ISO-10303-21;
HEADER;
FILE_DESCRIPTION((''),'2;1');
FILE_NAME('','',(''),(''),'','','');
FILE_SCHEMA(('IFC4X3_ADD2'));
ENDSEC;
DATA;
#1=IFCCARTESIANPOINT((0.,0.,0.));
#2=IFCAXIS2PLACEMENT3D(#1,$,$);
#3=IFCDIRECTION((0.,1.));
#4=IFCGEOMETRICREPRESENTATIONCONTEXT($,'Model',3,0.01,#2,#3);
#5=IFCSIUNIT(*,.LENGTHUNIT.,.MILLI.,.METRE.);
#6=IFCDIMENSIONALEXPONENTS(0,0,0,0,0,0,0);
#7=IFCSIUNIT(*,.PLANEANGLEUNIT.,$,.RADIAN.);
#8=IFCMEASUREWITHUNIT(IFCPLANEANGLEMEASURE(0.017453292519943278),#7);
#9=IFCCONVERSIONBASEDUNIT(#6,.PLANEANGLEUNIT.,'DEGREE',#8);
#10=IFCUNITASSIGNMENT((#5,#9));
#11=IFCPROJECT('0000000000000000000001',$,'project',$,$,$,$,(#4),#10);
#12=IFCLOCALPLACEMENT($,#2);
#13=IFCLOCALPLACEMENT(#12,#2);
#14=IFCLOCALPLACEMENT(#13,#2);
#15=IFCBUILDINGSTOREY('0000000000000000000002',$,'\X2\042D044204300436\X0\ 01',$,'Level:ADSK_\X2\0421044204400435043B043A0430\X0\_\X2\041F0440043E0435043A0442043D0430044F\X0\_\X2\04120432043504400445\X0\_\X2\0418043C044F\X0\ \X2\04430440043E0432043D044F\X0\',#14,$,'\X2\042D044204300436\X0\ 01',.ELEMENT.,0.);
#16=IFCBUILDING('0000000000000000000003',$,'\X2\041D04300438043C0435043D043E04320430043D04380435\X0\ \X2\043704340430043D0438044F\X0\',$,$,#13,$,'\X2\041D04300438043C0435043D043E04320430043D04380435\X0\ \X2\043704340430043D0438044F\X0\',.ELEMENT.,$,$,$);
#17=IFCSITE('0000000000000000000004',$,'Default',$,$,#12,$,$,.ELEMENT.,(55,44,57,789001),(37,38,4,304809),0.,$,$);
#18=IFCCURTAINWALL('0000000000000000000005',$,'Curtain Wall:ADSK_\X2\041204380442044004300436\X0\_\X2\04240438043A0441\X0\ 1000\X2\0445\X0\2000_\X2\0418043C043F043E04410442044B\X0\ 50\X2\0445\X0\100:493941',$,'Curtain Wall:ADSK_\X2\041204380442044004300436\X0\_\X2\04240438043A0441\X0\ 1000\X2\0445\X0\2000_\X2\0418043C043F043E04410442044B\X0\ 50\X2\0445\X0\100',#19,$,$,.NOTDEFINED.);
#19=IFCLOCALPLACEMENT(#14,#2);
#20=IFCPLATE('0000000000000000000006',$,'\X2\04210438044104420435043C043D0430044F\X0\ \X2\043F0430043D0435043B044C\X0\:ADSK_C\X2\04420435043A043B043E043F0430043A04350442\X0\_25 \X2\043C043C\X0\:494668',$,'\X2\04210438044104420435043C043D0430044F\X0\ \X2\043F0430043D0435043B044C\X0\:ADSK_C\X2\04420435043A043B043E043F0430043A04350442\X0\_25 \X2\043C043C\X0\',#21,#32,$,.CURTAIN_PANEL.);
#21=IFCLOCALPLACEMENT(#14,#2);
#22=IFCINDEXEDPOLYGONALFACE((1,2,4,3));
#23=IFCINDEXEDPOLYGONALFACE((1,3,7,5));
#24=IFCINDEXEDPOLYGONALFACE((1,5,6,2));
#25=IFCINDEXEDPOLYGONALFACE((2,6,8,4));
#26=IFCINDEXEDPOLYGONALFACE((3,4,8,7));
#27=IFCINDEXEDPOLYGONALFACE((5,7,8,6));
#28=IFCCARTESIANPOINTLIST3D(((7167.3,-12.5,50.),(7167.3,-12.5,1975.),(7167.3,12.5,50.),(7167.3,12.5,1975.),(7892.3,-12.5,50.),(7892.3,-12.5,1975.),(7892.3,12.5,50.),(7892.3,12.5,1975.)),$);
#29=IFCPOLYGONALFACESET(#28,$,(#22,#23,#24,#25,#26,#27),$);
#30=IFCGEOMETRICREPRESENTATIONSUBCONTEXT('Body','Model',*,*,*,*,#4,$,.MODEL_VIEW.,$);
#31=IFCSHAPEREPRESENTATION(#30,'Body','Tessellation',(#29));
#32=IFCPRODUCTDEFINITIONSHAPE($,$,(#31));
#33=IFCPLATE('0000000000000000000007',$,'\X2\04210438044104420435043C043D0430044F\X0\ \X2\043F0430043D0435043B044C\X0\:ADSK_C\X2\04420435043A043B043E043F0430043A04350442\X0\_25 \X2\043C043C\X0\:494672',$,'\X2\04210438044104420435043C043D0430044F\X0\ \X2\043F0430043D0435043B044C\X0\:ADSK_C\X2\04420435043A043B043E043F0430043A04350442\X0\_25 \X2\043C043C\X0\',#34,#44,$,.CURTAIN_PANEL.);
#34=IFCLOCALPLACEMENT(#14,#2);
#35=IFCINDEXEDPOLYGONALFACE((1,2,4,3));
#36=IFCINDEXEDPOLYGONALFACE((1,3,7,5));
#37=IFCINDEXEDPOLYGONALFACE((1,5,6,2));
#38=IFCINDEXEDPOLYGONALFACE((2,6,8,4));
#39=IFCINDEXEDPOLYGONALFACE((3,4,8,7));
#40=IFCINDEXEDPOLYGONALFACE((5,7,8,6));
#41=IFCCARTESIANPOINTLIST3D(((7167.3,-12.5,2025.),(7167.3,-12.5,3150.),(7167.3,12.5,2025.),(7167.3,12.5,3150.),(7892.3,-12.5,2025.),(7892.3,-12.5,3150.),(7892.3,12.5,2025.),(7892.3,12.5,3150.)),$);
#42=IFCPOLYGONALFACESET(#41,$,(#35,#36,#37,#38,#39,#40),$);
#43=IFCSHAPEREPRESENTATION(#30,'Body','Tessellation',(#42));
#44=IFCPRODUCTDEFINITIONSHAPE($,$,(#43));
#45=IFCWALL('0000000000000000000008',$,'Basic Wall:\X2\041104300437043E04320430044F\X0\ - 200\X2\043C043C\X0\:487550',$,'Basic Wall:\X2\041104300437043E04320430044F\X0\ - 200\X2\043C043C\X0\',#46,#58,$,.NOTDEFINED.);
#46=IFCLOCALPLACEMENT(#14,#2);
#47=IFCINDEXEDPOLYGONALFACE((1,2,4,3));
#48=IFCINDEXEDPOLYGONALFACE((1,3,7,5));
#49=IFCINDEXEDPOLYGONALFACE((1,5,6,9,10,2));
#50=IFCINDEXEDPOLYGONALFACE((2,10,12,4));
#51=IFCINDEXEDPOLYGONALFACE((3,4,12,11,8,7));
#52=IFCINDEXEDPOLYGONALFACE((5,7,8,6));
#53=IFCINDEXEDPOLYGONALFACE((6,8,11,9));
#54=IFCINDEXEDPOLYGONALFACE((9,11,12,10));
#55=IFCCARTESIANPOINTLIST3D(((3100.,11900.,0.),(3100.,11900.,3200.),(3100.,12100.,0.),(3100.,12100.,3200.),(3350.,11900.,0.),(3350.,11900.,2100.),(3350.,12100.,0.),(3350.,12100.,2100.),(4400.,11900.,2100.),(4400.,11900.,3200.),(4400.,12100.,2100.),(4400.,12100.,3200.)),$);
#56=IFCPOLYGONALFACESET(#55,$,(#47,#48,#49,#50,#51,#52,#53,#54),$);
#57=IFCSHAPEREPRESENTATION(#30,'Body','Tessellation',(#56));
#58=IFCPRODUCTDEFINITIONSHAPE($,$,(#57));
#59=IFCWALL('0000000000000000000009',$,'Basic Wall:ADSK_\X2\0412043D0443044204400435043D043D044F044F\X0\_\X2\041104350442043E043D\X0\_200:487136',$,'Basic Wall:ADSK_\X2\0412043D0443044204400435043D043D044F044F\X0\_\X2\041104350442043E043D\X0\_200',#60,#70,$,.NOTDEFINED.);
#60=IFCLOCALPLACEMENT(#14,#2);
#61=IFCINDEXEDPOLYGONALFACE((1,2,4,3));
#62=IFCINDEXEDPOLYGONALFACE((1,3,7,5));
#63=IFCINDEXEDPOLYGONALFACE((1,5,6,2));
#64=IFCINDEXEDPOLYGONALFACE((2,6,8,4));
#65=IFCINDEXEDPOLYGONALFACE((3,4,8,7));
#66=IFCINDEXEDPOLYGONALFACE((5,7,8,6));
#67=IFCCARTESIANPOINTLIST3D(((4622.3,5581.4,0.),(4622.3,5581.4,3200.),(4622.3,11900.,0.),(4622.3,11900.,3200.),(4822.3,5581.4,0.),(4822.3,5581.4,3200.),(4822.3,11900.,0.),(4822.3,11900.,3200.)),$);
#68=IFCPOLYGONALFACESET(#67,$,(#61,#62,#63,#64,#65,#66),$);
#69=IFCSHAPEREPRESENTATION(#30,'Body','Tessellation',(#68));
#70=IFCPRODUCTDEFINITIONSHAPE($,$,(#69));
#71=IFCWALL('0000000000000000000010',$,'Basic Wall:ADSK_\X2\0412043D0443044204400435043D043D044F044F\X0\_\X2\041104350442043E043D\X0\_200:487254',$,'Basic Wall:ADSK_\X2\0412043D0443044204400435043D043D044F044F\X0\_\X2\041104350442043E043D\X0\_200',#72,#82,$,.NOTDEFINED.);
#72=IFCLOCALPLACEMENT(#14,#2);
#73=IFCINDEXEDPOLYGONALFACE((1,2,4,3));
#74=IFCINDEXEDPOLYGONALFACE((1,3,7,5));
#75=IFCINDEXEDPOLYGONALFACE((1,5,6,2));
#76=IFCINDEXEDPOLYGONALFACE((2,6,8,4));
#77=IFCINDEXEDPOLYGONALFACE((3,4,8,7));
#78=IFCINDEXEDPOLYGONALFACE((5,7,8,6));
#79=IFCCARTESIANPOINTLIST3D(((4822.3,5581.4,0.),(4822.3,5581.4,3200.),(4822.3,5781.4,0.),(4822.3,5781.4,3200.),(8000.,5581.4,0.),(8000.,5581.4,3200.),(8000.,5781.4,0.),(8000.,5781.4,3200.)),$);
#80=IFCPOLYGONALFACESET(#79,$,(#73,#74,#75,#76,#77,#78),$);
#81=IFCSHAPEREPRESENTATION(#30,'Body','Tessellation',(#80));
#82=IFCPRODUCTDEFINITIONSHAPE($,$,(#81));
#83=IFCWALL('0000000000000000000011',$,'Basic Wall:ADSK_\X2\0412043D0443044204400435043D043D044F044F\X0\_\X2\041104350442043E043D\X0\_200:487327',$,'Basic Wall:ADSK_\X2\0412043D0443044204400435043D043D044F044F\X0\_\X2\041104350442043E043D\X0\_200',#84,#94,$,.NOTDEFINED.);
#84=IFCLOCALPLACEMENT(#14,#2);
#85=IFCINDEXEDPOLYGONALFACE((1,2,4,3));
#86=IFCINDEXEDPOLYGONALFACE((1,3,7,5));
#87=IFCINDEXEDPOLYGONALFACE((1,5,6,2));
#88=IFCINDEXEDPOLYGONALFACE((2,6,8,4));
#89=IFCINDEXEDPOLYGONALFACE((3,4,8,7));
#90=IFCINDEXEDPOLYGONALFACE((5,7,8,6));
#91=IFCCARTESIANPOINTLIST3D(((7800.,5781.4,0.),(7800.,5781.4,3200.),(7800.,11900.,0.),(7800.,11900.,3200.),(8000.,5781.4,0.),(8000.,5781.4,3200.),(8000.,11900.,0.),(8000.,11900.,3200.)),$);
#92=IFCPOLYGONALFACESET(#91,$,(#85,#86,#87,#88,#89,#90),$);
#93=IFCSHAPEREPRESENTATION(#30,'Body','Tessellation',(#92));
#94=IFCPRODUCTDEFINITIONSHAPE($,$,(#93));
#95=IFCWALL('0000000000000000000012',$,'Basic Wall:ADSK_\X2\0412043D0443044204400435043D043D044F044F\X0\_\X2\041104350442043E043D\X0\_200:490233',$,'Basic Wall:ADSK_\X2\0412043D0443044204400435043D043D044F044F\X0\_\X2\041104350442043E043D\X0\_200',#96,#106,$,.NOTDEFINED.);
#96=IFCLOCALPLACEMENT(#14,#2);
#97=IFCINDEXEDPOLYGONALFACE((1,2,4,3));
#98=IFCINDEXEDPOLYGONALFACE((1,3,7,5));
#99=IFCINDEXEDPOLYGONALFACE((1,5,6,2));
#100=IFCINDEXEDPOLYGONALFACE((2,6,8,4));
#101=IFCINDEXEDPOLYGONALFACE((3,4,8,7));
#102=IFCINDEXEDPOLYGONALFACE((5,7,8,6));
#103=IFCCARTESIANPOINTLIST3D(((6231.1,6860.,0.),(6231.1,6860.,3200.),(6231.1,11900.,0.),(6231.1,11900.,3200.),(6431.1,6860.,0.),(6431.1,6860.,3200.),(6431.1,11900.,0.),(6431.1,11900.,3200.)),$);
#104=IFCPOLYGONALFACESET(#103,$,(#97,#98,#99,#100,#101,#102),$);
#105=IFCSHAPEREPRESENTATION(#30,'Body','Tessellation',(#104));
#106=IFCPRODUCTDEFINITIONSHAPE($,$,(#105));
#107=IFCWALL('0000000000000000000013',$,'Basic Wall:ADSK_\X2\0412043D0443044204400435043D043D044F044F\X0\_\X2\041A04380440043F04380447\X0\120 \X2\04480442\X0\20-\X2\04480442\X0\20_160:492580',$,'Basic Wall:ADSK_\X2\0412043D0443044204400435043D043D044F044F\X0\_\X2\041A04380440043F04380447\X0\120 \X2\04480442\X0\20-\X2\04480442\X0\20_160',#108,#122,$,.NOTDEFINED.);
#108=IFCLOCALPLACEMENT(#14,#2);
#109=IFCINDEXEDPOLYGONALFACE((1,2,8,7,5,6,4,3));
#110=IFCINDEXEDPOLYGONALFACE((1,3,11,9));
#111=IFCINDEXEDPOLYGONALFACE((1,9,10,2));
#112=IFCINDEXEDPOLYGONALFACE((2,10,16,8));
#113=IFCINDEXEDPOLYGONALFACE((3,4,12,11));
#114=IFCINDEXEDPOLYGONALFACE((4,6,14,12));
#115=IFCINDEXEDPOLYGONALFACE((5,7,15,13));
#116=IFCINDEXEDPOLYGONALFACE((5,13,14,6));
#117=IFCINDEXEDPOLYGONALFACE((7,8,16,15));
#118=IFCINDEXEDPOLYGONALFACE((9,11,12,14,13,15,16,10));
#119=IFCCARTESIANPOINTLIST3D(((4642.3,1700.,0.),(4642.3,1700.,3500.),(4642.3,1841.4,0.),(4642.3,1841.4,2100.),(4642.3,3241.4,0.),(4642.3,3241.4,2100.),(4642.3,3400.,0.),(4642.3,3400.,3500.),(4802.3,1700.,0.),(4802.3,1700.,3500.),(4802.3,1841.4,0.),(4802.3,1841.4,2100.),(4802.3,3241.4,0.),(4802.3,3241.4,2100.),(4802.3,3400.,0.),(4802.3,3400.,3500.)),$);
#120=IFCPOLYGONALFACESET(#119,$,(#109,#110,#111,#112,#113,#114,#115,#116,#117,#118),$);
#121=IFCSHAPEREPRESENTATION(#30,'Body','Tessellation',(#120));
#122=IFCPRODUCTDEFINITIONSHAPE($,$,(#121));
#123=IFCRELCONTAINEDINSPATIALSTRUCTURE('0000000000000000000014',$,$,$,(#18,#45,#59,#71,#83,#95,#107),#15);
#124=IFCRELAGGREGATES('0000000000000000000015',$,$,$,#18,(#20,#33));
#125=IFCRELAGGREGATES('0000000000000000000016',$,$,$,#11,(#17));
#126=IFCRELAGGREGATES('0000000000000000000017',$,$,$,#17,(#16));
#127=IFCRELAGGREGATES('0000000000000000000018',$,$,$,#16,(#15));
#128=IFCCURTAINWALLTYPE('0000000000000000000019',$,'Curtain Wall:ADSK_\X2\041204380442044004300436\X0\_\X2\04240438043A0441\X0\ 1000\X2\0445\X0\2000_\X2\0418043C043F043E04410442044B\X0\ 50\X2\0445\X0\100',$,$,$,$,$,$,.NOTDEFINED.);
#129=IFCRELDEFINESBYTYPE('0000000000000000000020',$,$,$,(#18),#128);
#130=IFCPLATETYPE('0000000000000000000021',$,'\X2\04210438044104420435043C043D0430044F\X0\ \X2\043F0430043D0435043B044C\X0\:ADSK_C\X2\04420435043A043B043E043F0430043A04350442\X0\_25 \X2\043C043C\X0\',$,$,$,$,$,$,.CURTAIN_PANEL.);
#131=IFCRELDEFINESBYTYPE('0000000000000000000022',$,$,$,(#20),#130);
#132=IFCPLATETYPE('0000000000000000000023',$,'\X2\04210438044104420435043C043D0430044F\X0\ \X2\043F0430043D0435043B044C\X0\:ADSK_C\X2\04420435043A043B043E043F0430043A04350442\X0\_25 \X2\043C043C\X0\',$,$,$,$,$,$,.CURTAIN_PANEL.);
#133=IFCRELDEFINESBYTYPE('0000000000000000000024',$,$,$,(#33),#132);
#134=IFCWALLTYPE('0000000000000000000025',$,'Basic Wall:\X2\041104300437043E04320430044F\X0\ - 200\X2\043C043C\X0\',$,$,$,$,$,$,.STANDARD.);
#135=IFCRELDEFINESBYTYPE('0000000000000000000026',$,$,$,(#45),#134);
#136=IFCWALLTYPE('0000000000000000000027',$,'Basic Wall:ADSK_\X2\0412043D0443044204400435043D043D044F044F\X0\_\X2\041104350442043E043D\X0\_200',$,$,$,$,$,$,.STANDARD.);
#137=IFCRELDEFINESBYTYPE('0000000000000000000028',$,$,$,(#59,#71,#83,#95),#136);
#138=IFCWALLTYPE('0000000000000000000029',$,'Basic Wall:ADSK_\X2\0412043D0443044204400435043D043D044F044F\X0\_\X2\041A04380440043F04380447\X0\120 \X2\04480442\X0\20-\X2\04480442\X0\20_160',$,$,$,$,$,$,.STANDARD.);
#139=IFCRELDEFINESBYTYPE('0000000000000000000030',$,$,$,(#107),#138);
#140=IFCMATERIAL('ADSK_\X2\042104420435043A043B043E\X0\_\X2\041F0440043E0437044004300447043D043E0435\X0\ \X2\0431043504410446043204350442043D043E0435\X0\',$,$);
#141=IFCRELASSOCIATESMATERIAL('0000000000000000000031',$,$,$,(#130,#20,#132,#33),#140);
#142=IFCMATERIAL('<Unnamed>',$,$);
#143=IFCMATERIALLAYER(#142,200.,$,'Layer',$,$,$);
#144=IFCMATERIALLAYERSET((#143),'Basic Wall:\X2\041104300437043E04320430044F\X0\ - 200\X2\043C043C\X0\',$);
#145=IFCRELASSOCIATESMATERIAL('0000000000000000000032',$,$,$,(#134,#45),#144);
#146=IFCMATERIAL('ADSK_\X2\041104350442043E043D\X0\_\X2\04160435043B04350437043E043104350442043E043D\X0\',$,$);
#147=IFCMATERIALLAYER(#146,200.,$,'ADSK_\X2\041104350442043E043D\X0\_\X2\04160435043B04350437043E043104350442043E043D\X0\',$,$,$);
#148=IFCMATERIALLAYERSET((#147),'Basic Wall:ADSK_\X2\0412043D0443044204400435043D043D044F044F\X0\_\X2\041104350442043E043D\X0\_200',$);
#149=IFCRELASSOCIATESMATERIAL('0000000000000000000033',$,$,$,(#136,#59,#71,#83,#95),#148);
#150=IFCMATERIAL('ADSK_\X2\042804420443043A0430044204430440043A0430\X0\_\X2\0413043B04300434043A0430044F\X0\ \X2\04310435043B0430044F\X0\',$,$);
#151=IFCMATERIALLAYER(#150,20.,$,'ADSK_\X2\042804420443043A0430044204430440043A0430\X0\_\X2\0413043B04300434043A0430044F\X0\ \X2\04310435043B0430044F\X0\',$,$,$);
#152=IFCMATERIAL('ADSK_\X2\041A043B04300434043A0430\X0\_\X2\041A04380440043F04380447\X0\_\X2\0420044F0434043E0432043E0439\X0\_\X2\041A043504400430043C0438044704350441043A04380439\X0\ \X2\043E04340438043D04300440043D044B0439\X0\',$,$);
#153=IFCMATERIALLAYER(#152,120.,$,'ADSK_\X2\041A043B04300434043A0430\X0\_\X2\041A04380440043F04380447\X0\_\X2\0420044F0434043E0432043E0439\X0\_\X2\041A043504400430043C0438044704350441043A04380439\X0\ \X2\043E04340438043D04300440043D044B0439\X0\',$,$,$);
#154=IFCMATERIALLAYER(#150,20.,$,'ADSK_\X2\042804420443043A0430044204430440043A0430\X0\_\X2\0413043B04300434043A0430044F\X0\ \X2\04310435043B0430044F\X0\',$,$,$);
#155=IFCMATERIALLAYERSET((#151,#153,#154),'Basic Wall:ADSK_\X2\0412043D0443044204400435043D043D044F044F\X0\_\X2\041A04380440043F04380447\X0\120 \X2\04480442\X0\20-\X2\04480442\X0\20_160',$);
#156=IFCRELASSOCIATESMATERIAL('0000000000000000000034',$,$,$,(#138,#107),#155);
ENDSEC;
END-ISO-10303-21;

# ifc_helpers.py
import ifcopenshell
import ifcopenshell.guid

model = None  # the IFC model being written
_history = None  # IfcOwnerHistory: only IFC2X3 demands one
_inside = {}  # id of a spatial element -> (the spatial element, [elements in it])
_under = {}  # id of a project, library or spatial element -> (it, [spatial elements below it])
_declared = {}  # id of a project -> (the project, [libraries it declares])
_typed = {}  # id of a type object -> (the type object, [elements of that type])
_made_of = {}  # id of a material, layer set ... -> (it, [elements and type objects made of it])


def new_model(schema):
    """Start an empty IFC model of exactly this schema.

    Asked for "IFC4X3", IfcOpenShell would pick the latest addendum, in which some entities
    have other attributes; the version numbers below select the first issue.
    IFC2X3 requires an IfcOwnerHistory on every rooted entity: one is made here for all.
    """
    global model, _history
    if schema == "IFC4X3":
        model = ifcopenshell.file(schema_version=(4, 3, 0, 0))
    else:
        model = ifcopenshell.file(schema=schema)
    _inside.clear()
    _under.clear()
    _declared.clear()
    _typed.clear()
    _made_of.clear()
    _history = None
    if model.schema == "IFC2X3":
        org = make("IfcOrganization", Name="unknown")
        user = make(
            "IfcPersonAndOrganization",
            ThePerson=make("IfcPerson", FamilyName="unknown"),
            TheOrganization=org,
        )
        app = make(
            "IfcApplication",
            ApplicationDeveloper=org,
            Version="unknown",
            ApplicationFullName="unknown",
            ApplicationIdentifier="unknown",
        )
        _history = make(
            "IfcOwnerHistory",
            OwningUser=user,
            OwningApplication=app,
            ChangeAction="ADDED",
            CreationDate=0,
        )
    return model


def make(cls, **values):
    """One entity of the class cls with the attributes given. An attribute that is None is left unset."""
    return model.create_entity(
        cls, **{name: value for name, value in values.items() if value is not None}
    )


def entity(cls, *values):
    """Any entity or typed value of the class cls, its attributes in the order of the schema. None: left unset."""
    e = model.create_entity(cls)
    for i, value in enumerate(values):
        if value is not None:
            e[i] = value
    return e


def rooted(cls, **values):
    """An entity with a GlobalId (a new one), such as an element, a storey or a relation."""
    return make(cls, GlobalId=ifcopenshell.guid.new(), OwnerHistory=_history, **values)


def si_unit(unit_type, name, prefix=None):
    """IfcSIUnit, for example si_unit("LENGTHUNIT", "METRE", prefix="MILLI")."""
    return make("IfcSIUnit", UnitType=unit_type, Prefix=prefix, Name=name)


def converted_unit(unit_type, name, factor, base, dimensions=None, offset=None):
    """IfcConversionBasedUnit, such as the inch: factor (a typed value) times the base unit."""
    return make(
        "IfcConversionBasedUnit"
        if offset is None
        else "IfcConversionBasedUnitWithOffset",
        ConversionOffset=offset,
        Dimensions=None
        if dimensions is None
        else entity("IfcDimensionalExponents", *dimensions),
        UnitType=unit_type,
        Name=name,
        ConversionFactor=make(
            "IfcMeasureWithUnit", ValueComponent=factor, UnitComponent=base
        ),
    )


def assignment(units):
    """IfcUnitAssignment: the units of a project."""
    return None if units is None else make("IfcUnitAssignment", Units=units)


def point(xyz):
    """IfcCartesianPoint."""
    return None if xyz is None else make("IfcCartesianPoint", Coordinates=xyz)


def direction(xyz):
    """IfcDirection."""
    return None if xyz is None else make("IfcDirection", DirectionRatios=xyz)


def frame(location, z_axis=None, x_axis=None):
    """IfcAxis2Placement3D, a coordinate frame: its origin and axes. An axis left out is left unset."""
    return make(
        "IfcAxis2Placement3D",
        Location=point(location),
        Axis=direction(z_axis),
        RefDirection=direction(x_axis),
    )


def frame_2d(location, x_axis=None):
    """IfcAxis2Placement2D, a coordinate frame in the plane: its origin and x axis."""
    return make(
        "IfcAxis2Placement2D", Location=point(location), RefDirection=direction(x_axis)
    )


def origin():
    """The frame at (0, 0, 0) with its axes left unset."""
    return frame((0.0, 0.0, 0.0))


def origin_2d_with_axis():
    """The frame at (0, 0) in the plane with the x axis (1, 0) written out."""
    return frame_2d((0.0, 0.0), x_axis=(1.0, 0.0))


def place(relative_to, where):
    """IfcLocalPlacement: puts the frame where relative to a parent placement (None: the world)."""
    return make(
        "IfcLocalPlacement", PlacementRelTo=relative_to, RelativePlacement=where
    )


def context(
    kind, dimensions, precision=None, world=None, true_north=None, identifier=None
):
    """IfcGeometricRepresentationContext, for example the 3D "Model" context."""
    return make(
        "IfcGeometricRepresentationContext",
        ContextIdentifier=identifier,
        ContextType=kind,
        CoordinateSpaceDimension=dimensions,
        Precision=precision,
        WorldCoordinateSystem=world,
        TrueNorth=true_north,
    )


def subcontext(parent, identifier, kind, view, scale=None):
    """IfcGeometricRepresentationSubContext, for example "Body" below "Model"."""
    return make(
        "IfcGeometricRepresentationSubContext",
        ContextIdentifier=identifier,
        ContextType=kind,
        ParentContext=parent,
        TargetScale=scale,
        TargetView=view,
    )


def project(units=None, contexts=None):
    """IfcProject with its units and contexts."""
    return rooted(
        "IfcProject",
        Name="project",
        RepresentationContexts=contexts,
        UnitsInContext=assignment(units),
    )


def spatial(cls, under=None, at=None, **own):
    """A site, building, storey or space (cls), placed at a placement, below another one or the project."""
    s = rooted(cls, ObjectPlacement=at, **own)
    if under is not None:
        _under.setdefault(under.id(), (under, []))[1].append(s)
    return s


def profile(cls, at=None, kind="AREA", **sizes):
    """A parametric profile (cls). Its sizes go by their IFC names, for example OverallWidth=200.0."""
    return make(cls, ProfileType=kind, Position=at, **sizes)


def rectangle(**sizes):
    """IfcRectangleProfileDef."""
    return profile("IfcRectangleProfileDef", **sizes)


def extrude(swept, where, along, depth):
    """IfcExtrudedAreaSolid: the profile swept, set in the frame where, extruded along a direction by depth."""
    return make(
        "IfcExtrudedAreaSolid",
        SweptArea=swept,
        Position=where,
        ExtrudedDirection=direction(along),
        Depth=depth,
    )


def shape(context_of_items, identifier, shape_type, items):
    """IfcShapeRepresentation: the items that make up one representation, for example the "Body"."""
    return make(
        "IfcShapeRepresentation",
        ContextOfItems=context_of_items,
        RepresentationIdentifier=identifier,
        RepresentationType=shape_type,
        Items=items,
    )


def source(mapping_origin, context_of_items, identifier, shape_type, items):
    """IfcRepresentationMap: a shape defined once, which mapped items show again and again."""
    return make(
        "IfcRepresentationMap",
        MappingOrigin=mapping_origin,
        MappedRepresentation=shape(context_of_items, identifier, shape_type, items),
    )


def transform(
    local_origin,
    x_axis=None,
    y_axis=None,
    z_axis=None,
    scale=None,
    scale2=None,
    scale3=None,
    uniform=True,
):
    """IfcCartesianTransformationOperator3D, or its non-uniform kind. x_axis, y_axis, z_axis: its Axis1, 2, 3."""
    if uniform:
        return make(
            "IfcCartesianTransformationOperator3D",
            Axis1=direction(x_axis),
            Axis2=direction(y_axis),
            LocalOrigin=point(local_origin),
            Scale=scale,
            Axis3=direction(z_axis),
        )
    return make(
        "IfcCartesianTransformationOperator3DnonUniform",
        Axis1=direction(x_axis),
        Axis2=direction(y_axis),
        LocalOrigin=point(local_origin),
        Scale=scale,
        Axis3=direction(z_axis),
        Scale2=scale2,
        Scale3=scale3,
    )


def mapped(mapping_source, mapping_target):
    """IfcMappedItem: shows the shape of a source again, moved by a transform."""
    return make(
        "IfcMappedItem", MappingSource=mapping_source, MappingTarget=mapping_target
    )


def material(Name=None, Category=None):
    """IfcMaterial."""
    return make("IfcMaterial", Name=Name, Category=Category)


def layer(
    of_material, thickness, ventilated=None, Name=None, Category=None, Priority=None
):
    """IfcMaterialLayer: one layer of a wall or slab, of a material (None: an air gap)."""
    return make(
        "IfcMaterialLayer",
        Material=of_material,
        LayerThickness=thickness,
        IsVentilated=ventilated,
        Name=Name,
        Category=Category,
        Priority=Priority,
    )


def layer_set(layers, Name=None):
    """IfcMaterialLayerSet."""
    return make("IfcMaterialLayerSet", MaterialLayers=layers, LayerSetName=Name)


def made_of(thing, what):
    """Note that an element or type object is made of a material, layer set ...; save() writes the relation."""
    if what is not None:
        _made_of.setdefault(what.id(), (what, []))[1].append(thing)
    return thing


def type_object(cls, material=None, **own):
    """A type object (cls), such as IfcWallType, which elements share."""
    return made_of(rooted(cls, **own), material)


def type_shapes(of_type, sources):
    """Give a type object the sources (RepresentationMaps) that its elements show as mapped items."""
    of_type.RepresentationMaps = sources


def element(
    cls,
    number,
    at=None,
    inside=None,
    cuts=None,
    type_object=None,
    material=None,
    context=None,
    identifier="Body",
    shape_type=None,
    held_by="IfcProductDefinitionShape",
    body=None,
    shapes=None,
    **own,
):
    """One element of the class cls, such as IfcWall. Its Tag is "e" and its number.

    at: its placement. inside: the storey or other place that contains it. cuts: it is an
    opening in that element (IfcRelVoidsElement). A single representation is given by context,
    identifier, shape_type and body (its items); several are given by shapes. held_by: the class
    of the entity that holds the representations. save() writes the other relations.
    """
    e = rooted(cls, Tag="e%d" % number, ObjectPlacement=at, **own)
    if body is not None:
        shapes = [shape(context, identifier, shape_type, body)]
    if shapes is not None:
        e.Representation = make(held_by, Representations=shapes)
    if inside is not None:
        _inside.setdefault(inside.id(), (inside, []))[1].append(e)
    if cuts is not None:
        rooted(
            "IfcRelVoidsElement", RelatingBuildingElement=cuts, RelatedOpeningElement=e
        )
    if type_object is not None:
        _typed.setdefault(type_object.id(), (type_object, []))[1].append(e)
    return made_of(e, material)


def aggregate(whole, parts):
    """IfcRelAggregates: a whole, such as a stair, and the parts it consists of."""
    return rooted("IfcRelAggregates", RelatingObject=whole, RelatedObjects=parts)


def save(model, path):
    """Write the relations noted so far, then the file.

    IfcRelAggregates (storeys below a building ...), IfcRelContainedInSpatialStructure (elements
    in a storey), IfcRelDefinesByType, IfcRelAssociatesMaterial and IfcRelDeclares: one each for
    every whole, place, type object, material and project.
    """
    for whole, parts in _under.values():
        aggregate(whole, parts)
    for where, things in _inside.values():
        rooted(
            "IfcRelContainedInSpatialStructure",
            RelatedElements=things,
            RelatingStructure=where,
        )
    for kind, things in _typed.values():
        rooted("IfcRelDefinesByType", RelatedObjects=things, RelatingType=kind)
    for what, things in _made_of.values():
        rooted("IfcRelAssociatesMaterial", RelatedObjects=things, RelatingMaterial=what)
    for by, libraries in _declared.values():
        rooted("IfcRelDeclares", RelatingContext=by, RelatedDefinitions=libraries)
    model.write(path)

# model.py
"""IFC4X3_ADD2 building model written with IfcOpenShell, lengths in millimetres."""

from ifc_helpers import new_model, entity, si_unit, converted_unit, direction, frame, frame_2d, origin, origin_2d_with_axis, place, context, subcontext, project, spatial, rectangle, extrude, source, transform, mapped, material, layer, layer_set, type_object, type_shapes, element, aggregate, save


model = new_model("IFC4X3_ADD2")

# Units and contexts
model_context = context("Model", 3, precision=0.01, world=origin(), true_north=direction((0.0, 1.0)))
body_context = subcontext(model_context, "Body", "Model", "MODEL_VIEW")
ifc_project = project(units=[si_unit("LENGTHUNIT", "METRE", prefix="MILLI"), converted_unit("PLANEANGLEUNIT", "DEGREE", entity("IfcPlaneAngleMeasure", 0.017453292519943278), si_unit("PLANEANGLEUNIT", "RADIAN"), dimensions=[0, 0, 0, 0, 0, 0, 0])], contexts=[model_context])

# Site, building, storey
site_placement = place(None, origin())
site = spatial("IfcSite", under=ifc_project, at=site_placement, Name="Default", CompositionType="ELEMENT", RefLatitude=(55, 44, 57, 789001), RefLongitude=(37, 38, 4, 304809), RefElevation=0.0)
building_placement = place(site_placement, origin())
building = spatial("IfcBuilding", under=site, at=building_placement, Name="Наименование здания", LongName="Наименование здания", CompositionType="ELEMENT")
storey_placement = place(building_placement, origin())
storey = spatial("IfcBuildingStorey", under=building, at=storey_placement, Name="Этаж 01", ObjectType="Level:ADSK_Стрелка_Проектная_Вверх_Имя уровня", LongName="Этаж 01", CompositionType="ELEMENT", Elevation=0.0)

# Shared definitions
curtain_wall_type_1 = type_object("IfcCurtainWallType", Name="Curtain Wall:ADSK_Витраж_Фикс 1000х2000_Импосты 50х100", PredefinedType="NOTDEFINED")
ifc_material_1 = material(Name="ADSK_Стекло_Прозрачное бесцветное")

# Curtain wall
curtain_wall_1_placement = place(storey_placement, origin())
curtain_wall_1 = element("IfcCurtainWall", 1, at=curtain_wall_1_placement, inside=storey, type_object=curtain_wall_type_1, Name="Curtain Wall:ADSK_Витраж_Фикс 1000х2000_Импосты 50х100:493941", ObjectType="Curtain Wall:ADSK_Витраж_Фикс 1000х2000_Импосты 50х100", PredefinedType="NOTDEFINED")

# Plates
plate_type_1 = type_object("IfcPlateType", Name="Системная панель:ADSK_Cтеклопакет_25 мм", PredefinedType="CURTAIN_PANEL", material=ifc_material_1)
shared_shape_1 = source(origin(), body_context, "Body", "SweptSolid", [
    extrude(rectangle(XDim=25.0, YDim=725.0, at=origin_2d_with_axis()), frame((0.0, 0.0, 0.0), z_axis=(0.0, 0.0, 1.0), x_axis=(0.0, 1.0, 0.0)), (0.0, 0.0, 1.0), 1925.0),
])
type_shapes(plate_type_1, [shared_shape_1])
plate_1_placement = place(curtain_wall_1_placement, frame((7529.8, 0.0, 50.0)))
plate_1 = element("IfcPlate", 2, at=plate_1_placement, type_object=plate_type_1, material=ifc_material_1, Name="Системная панель:ADSK_Cтеклопакет_25 мм:494668", ObjectType="Системная панель:ADSK_Cтеклопакет_25 мм", PredefinedType="CURTAIN_PANEL", context=body_context, shape_type="MappedRepresentation", body=[
    mapped(shared_shape_1, transform((0.0, 0.0, 0.0), scale=1.0)),
])
plate_type_2 = type_object("IfcPlateType", Name="Системная панель:ADSK_Cтеклопакет_25 мм", PredefinedType="CURTAIN_PANEL", material=ifc_material_1)
shared_shape_2 = source(origin(), body_context, "Body", "SweptSolid", [
    extrude(rectangle(XDim=25.0, YDim=725.0, at=origin_2d_with_axis()), frame((0.0, 0.0, 0.0), z_axis=(0.0, 0.0, 1.0), x_axis=(0.0, 1.0, 0.0)), (0.0, 0.0, 1.0), 1125.0),
])
type_shapes(plate_type_2, [shared_shape_2])
plate_2_placement = place(curtain_wall_1_placement, frame((7529.8, 0.0, 2025.0)))
plate_2 = element("IfcPlate", 3, at=plate_2_placement, type_object=plate_type_2, material=ifc_material_1, Name="Системная панель:ADSK_Cтеклопакет_25 мм:494672", ObjectType="Системная панель:ADSK_Cтеклопакет_25 мм", PredefinedType="CURTAIN_PANEL", context=body_context, shape_type="MappedRepresentation", body=[
    mapped(shared_shape_2, transform((0.0, 0.0, 0.0), scale=1.0)),
])
aggregate(curtain_wall_1, [plate_1, plate_2])

# Wall, opening
ifc_material_2 = material(Name="<Unnamed>")
ifc_layer_1 = layer(ifc_material_2, 200.0, Name="Layer")
ifc_layer_set_1 = layer_set([ifc_layer_1], Name="Basic Wall:Базовая - 200мм")
wall_type_1 = type_object("IfcWallType", Name="Basic Wall:Базовая - 200мм", PredefinedType="STANDARD", material=ifc_layer_set_1)
wall_1_placement = place(storey_placement, frame((4400.0, 12000.0, 0.0), z_axis=(0.0, 0.0, 1.0), x_axis=(-1.0, 0.0, 0.0)))
wall_1 = element("IfcWall", 4, at=wall_1_placement, inside=storey, type_object=wall_type_1, material=ifc_layer_set_1, Name="Basic Wall:Базовая - 200мм:487550", ObjectType="Basic Wall:Базовая - 200мм", PredefinedType="NOTDEFINED", context=body_context, shape_type="SweptSolid", body=[
    extrude(rectangle(XDim=1300.0, YDim=200.0, at=frame_2d((650.0, 0.0), x_axis=(-1.0, 0.0))), origin(), (0.0, 0.0, 1.0), 3200.0),
])
opening_1_placement = place(wall_1_placement, frame((4400.0, 12000.0, 0.0), z_axis=(0.0, 0.0, 1.0), x_axis=(-1.0, 0.0, 0.0)))
element("IfcOpeningElement", 5, at=opening_1_placement, cuts=wall_1, PredefinedType="OPENING", context=body_context, shape_type="SweptSolid", body=[
    extrude(rectangle(XDim=2100.0, YDim=1100.0, at=frame_2d((0.0, 0.0), x_axis=(0.0, 1.0))), frame((3900.0, 12600.0, 1050.0), z_axis=(0.0, -1.0, 0.0), x_axis=(-1.0, 0.0, 0.0)), (0.0, 0.0, 1.0), 1200.0),
])

# Walls
ifc_material_3 = material(Name="ADSK_Бетон_Железобетон")
ifc_layer_2 = layer(ifc_material_3, 200.0, Name="ADSK_Бетон_Железобетон")
ifc_layer_set_2 = layer_set([ifc_layer_2], Name="Basic Wall:ADSK_Внутренняя_Бетон_200")
wall_type_2 = type_object("IfcWallType", Name="Basic Wall:ADSK_Внутренняя_Бетон_200", PredefinedType="STANDARD", material=ifc_layer_set_2)
wall_2_placement = place(storey_placement, frame((4722.3, 11900.0, 0.0), z_axis=(0.0, 0.0, 1.0), x_axis=(0.0, -1.0, 0.0)))
element("IfcWall", 6, at=wall_2_placement, inside=storey, type_object=wall_type_2, material=ifc_layer_set_2, Name="Basic Wall:ADSK_Внутренняя_Бетон_200:487136", ObjectType="Basic Wall:ADSK_Внутренняя_Бетон_200", PredefinedType="NOTDEFINED", context=body_context, shape_type="SweptSolid", body=[
    extrude(rectangle(XDim=6318.6, YDim=200.0, at=frame_2d((3159.3, 0.0), x_axis=(-1.0, 0.0))), origin(), (0.0, 0.0, 1.0), 3200.0),
])
wall_3_placement = place(storey_placement, frame((4822.3, 5681.4, 0.0)))
element("IfcWall", 7, at=wall_3_placement, inside=storey, type_object=wall_type_2, material=ifc_layer_set_2, Name="Basic Wall:ADSK_Внутренняя_Бетон_200:487254", ObjectType="Basic Wall:ADSK_Внутренняя_Бетон_200", PredefinedType="NOTDEFINED", context=body_context, shape_type="SweptSolid", body=[
    extrude(rectangle(XDim=3177.7, YDim=200.0, at=frame_2d((1588.9, 0.0), x_axis=(-1.0, 0.0))), origin(), (0.0, 0.0, 1.0), 3200.0),
])
wall_4_placement = place(storey_placement, frame((7900.0, 5781.4, 0.0), z_axis=(0.0, 0.0, 1.0), x_axis=(0.0, 1.0, 0.0)))
element("IfcWall", 8, at=wall_4_placement, inside=storey, type_object=wall_type_2, material=ifc_layer_set_2, Name="Basic Wall:ADSK_Внутренняя_Бетон_200:487327", ObjectType="Basic Wall:ADSK_Внутренняя_Бетон_200", PredefinedType="NOTDEFINED", context=body_context, shape_type="SweptSolid", body=[
    extrude(rectangle(XDim=6118.6, YDim=200.0, at=frame_2d((3059.3, 0.0), x_axis=(-1.0, 0.0))), origin(), (0.0, 0.0, 1.0), 3200.0),
])
wall_5_placement = place(storey_placement, frame((6331.1, 11900.0, 0.0), z_axis=(0.0, 0.0, 1.0), x_axis=(0.0, -1.0, 0.0)))
element("IfcWall", 9, at=wall_5_placement, inside=storey, type_object=wall_type_2, material=ifc_layer_set_2, Name="Basic Wall:ADSK_Внутренняя_Бетон_200:490233", ObjectType="Basic Wall:ADSK_Внутренняя_Бетон_200", PredefinedType="NOTDEFINED", context=body_context, shape_type="SweptSolid", body=[
    extrude(rectangle(XDim=5040.0, YDim=200.0, at=frame_2d((2520.0, 0.0), x_axis=(-1.0, 0.0))), origin(), (0.0, 0.0, 1.0), 3200.0),
])

# Wall, opening
ifc_material_4 = material(Name="ADSK_Штукатурка_Гладкая белая")
ifc_layer_3 = layer(ifc_material_4, 20.0, Name="ADSK_Штукатурка_Гладкая белая")
ifc_material_5 = material(Name="ADSK_Кладка_Кирпич_Рядовой_Керамический одинарный")
ifc_layer_4 = layer(ifc_material_5, 120.0, Name="ADSK_Кладка_Кирпич_Рядовой_Керамический одинарный")
ifc_layer_5 = layer(ifc_material_4, 20.0, Name="ADSK_Штукатурка_Гладкая белая")
ifc_layer_set_3 = layer_set([ifc_layer_3, ifc_layer_4, ifc_layer_5], Name="Basic Wall:ADSK_Внутренняя_Кирпич120 шт20-шт20_160")
wall_type_3 = type_object("IfcWallType", Name="Basic Wall:ADSK_Внутренняя_Кирпич120 шт20-шт20_160", PredefinedType="STANDARD", material=ifc_layer_set_3)
wall_6_placement = place(storey_placement, frame((4722.3, 3400.0, 0.0), z_axis=(0.0, 0.0, 1.0), x_axis=(0.0, -1.0, 0.0)))
wall_6 = element("IfcWall", 10, at=wall_6_placement, inside=storey, type_object=wall_type_3, material=ifc_layer_set_3, Name="Basic Wall:ADSK_Внутренняя_Кирпич120 шт20-шт20_160:492580", ObjectType="Basic Wall:ADSK_Внутренняя_Кирпич120 шт20-шт20_160", PredefinedType="NOTDEFINED", context=body_context, shape_type="SweptSolid", body=[
    extrude(rectangle(XDim=1700.0, YDim=160.0, at=frame_2d((850.0, 0.0), x_axis=(-1.0, 0.0))), origin(), (0.0, 0.0, 1.0), 3500.0),
])
opening_2_placement = place(wall_6_placement, frame((3400.0, -4722.3, 0.0), z_axis=(0.0, 0.0, 1.0), x_axis=(0.0, 1.0, 0.0)))
element("IfcOpeningElement", 11, at=opening_2_placement, cuts=wall_6, PredefinedType="OPENING", context=body_context, shape_type="SweptSolid", body=[
    extrude(rectangle(XDim=2100.0, YDim=1400.0, at=frame_2d((0.0, 0.0), x_axis=(0.0, 1.0))), frame((4142.3, 2541.4, 1050.0), z_axis=(1.0, 0.0, 0.0), x_axis=(0.0, -1.0, 0.0)), (0.0, 0.0, 1.0), 1160.0),
])

save(model, "model.ifc")
